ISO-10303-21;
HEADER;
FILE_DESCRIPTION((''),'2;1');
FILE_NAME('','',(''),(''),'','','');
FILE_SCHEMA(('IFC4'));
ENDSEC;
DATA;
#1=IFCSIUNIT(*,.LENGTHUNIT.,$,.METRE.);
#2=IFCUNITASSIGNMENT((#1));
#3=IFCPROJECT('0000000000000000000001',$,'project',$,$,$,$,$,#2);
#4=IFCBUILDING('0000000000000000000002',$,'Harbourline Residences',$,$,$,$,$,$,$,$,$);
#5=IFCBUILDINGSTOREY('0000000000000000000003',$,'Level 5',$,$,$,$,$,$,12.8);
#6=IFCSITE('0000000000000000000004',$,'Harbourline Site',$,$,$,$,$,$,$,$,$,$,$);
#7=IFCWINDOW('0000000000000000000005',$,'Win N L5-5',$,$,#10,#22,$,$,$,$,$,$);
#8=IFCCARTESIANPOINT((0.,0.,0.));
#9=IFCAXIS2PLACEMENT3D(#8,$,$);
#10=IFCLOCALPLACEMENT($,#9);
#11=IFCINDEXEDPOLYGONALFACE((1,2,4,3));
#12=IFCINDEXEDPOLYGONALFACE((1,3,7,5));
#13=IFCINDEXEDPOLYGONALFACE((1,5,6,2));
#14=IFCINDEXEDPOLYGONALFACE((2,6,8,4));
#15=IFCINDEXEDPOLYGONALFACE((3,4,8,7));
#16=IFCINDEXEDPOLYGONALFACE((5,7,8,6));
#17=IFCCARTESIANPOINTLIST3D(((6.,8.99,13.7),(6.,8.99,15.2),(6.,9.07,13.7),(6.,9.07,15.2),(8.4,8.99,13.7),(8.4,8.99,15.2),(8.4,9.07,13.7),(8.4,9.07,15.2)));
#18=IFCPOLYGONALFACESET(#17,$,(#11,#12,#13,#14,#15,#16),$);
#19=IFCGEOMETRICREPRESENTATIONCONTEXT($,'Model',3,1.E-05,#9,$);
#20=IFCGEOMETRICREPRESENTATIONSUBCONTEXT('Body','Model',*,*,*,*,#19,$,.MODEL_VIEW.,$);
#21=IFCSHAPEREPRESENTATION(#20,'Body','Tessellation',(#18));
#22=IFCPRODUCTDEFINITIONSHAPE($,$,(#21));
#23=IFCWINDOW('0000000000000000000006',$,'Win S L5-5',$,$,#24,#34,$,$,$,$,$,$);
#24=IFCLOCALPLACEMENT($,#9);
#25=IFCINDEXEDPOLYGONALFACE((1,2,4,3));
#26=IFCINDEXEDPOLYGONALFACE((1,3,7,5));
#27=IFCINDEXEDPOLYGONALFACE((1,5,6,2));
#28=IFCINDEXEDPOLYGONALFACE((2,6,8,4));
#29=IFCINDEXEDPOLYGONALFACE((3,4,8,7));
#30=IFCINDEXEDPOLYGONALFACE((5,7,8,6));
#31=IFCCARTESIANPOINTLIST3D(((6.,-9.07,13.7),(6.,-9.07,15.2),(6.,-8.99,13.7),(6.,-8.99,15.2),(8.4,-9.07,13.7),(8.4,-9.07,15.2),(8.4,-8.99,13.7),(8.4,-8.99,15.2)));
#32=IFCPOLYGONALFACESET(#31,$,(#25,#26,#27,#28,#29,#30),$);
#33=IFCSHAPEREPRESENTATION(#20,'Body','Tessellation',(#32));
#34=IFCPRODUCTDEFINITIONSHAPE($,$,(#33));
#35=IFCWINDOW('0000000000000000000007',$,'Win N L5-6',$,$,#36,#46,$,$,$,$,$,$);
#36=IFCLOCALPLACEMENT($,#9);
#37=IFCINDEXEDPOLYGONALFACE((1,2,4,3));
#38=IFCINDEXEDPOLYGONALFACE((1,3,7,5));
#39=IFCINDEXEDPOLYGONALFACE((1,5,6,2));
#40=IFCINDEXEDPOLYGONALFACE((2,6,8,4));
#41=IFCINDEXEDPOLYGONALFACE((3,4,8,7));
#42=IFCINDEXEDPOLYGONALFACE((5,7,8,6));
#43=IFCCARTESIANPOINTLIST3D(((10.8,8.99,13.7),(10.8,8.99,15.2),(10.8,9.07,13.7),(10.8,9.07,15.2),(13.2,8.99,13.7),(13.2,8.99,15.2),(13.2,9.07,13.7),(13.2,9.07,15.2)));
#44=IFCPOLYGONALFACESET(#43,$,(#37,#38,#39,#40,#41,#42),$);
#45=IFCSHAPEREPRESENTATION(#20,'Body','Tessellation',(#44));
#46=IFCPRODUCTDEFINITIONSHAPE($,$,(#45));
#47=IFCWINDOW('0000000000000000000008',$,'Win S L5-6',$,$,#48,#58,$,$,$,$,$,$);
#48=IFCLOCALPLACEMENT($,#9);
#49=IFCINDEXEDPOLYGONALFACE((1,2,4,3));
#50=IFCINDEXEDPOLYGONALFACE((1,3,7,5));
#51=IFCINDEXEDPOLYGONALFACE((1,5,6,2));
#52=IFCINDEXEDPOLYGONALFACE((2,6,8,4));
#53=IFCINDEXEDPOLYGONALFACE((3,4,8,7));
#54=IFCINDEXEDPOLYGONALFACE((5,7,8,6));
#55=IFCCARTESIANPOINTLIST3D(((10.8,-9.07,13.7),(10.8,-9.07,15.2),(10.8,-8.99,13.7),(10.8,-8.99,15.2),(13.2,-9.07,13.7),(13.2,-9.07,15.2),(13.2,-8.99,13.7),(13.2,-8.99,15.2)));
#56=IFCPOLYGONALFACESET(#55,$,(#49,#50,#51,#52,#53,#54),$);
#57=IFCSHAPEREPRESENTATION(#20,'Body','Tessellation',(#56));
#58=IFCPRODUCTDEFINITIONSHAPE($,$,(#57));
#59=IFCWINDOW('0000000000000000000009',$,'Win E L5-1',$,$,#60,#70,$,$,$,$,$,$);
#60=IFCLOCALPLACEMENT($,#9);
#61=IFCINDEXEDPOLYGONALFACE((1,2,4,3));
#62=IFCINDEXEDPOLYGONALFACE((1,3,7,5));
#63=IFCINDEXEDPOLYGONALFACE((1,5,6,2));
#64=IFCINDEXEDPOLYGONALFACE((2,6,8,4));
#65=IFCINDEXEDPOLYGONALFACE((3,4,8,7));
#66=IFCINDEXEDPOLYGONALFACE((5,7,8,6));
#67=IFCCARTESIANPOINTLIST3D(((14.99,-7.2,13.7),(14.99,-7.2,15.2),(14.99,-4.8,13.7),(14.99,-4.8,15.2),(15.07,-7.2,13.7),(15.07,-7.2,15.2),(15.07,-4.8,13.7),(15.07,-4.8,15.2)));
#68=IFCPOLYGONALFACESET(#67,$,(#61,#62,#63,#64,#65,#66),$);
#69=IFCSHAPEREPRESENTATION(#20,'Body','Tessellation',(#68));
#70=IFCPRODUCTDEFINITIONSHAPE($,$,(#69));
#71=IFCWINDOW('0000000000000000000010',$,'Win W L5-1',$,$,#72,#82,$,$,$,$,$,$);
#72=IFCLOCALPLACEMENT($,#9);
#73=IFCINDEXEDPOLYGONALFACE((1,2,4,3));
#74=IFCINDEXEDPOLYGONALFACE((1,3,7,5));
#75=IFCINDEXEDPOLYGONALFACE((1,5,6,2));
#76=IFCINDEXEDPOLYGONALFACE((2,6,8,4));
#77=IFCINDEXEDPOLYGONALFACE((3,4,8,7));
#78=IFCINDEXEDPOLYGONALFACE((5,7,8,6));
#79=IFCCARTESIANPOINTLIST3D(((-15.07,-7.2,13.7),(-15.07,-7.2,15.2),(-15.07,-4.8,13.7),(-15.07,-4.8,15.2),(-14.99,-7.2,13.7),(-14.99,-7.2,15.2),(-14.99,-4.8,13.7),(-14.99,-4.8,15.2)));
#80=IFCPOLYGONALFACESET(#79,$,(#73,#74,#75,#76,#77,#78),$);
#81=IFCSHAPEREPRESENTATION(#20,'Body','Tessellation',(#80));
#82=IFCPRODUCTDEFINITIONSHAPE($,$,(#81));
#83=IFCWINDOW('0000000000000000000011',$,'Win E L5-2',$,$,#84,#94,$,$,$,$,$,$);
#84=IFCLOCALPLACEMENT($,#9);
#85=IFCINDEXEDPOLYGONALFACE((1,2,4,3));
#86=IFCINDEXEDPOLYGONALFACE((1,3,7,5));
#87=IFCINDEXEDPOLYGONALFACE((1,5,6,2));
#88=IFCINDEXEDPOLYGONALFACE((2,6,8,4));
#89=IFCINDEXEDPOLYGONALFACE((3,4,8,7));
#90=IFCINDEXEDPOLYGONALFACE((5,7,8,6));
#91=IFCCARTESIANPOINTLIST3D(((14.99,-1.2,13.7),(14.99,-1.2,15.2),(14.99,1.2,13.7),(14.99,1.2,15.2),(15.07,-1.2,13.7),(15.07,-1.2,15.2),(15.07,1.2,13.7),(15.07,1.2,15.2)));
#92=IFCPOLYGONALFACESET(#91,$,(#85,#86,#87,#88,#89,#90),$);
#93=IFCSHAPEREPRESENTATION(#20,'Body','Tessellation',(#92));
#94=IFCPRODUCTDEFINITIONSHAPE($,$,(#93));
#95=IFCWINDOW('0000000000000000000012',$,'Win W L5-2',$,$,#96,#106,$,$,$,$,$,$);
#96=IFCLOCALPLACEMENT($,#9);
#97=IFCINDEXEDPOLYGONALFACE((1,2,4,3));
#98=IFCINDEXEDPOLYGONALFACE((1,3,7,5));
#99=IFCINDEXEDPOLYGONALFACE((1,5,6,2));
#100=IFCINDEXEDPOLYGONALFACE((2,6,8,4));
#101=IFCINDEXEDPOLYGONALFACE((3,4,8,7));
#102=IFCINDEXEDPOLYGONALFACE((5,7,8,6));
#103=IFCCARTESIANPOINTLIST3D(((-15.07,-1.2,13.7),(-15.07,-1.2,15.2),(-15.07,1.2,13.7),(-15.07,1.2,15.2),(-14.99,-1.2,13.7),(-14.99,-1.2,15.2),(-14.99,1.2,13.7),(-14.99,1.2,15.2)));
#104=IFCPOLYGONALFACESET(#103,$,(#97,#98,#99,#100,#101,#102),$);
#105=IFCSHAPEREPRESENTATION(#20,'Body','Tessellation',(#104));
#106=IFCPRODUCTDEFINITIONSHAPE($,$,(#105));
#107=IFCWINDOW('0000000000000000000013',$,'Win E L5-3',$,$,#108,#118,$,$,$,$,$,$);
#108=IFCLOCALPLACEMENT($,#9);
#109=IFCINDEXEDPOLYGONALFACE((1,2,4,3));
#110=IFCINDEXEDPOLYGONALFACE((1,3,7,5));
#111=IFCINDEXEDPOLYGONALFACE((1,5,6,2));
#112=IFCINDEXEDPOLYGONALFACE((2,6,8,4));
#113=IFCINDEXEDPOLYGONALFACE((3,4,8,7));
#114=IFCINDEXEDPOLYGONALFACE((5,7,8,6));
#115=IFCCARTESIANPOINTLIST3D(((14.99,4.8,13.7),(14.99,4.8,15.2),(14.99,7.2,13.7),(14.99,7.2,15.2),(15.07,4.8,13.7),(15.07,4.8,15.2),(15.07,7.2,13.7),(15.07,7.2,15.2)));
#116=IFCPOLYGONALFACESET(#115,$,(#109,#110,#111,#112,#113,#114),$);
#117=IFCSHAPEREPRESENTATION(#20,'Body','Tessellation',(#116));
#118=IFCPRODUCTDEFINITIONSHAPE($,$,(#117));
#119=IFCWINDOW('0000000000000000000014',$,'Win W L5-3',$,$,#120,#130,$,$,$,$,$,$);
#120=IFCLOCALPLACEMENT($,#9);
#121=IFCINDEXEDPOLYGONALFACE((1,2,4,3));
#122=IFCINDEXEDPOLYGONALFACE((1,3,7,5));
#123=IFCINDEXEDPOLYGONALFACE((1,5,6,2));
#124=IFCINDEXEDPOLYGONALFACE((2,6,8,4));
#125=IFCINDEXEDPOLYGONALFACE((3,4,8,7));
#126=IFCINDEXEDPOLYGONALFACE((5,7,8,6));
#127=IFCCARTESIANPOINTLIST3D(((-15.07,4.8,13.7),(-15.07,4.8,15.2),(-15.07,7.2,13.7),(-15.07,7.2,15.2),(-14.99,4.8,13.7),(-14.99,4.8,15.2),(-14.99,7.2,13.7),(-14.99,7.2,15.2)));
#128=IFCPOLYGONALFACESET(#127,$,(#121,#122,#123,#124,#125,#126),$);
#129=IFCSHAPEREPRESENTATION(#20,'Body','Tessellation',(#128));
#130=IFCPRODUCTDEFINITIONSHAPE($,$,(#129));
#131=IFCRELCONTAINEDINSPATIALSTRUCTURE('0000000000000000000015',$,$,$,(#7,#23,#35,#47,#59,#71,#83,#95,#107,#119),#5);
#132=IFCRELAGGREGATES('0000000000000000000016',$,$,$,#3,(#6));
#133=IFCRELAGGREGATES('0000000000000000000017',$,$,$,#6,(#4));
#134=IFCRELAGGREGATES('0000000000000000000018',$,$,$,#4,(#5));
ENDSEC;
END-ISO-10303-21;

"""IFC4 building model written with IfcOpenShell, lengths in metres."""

from ifc_helpers import new_model, si_unit, frame, frame_2d, origin, context, subcontext, project, spatial, rectangle, extrude, element, save


model = new_model("IFC4")

# Units and contexts
model_context = context("Model", 3, precision=1e-05, world=origin())
body_context = subcontext(model_context, "Body", "Model", "MODEL_VIEW")
ifc_project = project(units=[si_unit("LENGTHUNIT", "METRE")])

# Site, building, storey
site = spatial("IfcSite", under=ifc_project, Name="Harbourline Site")
building = spatial("IfcBuilding", under=site, Name="Harbourline Residences")
storey = spatial("IfcBuildingStorey", under=building, Name="Level 5", Elevation=12.8)

# Windows
element("IfcWindow", 1, inside=storey, Name="Win N L5-5", context=body_context, shape_type="SweptSolid", body=[
    extrude(rectangle(XDim=2.4, YDim=0.08, at=frame_2d((7.2, 9.03))), frame((0.0, 0.0, 13.7)), (0.0, 0.0, 1.0), 1.5),
])
element("IfcWindow", 2, inside=storey, Name="Win S L5-5", context=body_context, shape_type="SweptSolid", body=[
    extrude(rectangle(XDim=2.4, YDim=0.08, at=frame_2d((7.2, -9.03))), frame((0.0, 0.0, 13.7)), (0.0, 0.0, 1.0), 1.5),
])
element("IfcWindow", 3, inside=storey, Name="Win N L5-6", context=body_context, shape_type="SweptSolid", body=[
    extrude(rectangle(XDim=2.4, YDim=0.08, at=frame_2d((12.0, 9.03))), frame((0.0, 0.0, 13.7)), (0.0, 0.0, 1.0), 1.5),
])
element("IfcWindow", 4, inside=storey, Name="Win S L5-6", context=body_context, shape_type="SweptSolid", body=[
    extrude(rectangle(XDim=2.4, YDim=0.08, at=frame_2d((12.0, -9.03))), frame((0.0, 0.0, 13.7)), (0.0, 0.0, 1.0), 1.5),
])
element("IfcWindow", 5, inside=storey, Name="Win E L5-1", context=body_context, shape_type="SweptSolid", body=[
    extrude(rectangle(XDim=0.08, YDim=2.4, at=frame_2d((15.03, -6.0))), frame((0.0, 0.0, 13.7)), (0.0, 0.0, 1.0), 1.5),
])
element("IfcWindow", 6, inside=storey, Name="Win W L5-1", context=body_context, shape_type="SweptSolid", body=[
    extrude(rectangle(XDim=0.08, YDim=2.4, at=frame_2d((-15.03, -6.0))), frame((0.0, 0.0, 13.7)), (0.0, 0.0, 1.0), 1.5),
])
element("IfcWindow", 7, inside=storey, Name="Win E L5-2", context=body_context, shape_type="SweptSolid", body=[
    extrude(rectangle(XDim=0.08, YDim=2.4, at=frame_2d((15.03, 0.0))), frame((0.0, 0.0, 13.7)), (0.0, 0.0, 1.0), 1.5),
])
element("IfcWindow", 8, inside=storey, Name="Win W L5-2", context=body_context, shape_type="SweptSolid", body=[
    extrude(rectangle(XDim=0.08, YDim=2.4, at=frame_2d((-15.03, 0.0))), frame((0.0, 0.0, 13.7)), (0.0, 0.0, 1.0), 1.5),
])
element("IfcWindow", 9, inside=storey, Name="Win E L5-3", context=body_context, shape_type="SweptSolid", body=[
    extrude(rectangle(XDim=0.08, YDim=2.4, at=frame_2d((15.03, 6.0))), frame((0.0, 0.0, 13.7)), (0.0, 0.0, 1.0), 1.5),
])
element("IfcWindow", 10, inside=storey, Name="Win W L5-3", context=body_context, shape_type="SweptSolid", body=[
    extrude(rectangle(XDim=0.08, YDim=2.4, at=frame_2d((-15.03, 6.0))), frame((0.0, 0.0, 13.7)), (0.0, 0.0, 1.0), 1.5),
])

save(model, "model.ifc")
